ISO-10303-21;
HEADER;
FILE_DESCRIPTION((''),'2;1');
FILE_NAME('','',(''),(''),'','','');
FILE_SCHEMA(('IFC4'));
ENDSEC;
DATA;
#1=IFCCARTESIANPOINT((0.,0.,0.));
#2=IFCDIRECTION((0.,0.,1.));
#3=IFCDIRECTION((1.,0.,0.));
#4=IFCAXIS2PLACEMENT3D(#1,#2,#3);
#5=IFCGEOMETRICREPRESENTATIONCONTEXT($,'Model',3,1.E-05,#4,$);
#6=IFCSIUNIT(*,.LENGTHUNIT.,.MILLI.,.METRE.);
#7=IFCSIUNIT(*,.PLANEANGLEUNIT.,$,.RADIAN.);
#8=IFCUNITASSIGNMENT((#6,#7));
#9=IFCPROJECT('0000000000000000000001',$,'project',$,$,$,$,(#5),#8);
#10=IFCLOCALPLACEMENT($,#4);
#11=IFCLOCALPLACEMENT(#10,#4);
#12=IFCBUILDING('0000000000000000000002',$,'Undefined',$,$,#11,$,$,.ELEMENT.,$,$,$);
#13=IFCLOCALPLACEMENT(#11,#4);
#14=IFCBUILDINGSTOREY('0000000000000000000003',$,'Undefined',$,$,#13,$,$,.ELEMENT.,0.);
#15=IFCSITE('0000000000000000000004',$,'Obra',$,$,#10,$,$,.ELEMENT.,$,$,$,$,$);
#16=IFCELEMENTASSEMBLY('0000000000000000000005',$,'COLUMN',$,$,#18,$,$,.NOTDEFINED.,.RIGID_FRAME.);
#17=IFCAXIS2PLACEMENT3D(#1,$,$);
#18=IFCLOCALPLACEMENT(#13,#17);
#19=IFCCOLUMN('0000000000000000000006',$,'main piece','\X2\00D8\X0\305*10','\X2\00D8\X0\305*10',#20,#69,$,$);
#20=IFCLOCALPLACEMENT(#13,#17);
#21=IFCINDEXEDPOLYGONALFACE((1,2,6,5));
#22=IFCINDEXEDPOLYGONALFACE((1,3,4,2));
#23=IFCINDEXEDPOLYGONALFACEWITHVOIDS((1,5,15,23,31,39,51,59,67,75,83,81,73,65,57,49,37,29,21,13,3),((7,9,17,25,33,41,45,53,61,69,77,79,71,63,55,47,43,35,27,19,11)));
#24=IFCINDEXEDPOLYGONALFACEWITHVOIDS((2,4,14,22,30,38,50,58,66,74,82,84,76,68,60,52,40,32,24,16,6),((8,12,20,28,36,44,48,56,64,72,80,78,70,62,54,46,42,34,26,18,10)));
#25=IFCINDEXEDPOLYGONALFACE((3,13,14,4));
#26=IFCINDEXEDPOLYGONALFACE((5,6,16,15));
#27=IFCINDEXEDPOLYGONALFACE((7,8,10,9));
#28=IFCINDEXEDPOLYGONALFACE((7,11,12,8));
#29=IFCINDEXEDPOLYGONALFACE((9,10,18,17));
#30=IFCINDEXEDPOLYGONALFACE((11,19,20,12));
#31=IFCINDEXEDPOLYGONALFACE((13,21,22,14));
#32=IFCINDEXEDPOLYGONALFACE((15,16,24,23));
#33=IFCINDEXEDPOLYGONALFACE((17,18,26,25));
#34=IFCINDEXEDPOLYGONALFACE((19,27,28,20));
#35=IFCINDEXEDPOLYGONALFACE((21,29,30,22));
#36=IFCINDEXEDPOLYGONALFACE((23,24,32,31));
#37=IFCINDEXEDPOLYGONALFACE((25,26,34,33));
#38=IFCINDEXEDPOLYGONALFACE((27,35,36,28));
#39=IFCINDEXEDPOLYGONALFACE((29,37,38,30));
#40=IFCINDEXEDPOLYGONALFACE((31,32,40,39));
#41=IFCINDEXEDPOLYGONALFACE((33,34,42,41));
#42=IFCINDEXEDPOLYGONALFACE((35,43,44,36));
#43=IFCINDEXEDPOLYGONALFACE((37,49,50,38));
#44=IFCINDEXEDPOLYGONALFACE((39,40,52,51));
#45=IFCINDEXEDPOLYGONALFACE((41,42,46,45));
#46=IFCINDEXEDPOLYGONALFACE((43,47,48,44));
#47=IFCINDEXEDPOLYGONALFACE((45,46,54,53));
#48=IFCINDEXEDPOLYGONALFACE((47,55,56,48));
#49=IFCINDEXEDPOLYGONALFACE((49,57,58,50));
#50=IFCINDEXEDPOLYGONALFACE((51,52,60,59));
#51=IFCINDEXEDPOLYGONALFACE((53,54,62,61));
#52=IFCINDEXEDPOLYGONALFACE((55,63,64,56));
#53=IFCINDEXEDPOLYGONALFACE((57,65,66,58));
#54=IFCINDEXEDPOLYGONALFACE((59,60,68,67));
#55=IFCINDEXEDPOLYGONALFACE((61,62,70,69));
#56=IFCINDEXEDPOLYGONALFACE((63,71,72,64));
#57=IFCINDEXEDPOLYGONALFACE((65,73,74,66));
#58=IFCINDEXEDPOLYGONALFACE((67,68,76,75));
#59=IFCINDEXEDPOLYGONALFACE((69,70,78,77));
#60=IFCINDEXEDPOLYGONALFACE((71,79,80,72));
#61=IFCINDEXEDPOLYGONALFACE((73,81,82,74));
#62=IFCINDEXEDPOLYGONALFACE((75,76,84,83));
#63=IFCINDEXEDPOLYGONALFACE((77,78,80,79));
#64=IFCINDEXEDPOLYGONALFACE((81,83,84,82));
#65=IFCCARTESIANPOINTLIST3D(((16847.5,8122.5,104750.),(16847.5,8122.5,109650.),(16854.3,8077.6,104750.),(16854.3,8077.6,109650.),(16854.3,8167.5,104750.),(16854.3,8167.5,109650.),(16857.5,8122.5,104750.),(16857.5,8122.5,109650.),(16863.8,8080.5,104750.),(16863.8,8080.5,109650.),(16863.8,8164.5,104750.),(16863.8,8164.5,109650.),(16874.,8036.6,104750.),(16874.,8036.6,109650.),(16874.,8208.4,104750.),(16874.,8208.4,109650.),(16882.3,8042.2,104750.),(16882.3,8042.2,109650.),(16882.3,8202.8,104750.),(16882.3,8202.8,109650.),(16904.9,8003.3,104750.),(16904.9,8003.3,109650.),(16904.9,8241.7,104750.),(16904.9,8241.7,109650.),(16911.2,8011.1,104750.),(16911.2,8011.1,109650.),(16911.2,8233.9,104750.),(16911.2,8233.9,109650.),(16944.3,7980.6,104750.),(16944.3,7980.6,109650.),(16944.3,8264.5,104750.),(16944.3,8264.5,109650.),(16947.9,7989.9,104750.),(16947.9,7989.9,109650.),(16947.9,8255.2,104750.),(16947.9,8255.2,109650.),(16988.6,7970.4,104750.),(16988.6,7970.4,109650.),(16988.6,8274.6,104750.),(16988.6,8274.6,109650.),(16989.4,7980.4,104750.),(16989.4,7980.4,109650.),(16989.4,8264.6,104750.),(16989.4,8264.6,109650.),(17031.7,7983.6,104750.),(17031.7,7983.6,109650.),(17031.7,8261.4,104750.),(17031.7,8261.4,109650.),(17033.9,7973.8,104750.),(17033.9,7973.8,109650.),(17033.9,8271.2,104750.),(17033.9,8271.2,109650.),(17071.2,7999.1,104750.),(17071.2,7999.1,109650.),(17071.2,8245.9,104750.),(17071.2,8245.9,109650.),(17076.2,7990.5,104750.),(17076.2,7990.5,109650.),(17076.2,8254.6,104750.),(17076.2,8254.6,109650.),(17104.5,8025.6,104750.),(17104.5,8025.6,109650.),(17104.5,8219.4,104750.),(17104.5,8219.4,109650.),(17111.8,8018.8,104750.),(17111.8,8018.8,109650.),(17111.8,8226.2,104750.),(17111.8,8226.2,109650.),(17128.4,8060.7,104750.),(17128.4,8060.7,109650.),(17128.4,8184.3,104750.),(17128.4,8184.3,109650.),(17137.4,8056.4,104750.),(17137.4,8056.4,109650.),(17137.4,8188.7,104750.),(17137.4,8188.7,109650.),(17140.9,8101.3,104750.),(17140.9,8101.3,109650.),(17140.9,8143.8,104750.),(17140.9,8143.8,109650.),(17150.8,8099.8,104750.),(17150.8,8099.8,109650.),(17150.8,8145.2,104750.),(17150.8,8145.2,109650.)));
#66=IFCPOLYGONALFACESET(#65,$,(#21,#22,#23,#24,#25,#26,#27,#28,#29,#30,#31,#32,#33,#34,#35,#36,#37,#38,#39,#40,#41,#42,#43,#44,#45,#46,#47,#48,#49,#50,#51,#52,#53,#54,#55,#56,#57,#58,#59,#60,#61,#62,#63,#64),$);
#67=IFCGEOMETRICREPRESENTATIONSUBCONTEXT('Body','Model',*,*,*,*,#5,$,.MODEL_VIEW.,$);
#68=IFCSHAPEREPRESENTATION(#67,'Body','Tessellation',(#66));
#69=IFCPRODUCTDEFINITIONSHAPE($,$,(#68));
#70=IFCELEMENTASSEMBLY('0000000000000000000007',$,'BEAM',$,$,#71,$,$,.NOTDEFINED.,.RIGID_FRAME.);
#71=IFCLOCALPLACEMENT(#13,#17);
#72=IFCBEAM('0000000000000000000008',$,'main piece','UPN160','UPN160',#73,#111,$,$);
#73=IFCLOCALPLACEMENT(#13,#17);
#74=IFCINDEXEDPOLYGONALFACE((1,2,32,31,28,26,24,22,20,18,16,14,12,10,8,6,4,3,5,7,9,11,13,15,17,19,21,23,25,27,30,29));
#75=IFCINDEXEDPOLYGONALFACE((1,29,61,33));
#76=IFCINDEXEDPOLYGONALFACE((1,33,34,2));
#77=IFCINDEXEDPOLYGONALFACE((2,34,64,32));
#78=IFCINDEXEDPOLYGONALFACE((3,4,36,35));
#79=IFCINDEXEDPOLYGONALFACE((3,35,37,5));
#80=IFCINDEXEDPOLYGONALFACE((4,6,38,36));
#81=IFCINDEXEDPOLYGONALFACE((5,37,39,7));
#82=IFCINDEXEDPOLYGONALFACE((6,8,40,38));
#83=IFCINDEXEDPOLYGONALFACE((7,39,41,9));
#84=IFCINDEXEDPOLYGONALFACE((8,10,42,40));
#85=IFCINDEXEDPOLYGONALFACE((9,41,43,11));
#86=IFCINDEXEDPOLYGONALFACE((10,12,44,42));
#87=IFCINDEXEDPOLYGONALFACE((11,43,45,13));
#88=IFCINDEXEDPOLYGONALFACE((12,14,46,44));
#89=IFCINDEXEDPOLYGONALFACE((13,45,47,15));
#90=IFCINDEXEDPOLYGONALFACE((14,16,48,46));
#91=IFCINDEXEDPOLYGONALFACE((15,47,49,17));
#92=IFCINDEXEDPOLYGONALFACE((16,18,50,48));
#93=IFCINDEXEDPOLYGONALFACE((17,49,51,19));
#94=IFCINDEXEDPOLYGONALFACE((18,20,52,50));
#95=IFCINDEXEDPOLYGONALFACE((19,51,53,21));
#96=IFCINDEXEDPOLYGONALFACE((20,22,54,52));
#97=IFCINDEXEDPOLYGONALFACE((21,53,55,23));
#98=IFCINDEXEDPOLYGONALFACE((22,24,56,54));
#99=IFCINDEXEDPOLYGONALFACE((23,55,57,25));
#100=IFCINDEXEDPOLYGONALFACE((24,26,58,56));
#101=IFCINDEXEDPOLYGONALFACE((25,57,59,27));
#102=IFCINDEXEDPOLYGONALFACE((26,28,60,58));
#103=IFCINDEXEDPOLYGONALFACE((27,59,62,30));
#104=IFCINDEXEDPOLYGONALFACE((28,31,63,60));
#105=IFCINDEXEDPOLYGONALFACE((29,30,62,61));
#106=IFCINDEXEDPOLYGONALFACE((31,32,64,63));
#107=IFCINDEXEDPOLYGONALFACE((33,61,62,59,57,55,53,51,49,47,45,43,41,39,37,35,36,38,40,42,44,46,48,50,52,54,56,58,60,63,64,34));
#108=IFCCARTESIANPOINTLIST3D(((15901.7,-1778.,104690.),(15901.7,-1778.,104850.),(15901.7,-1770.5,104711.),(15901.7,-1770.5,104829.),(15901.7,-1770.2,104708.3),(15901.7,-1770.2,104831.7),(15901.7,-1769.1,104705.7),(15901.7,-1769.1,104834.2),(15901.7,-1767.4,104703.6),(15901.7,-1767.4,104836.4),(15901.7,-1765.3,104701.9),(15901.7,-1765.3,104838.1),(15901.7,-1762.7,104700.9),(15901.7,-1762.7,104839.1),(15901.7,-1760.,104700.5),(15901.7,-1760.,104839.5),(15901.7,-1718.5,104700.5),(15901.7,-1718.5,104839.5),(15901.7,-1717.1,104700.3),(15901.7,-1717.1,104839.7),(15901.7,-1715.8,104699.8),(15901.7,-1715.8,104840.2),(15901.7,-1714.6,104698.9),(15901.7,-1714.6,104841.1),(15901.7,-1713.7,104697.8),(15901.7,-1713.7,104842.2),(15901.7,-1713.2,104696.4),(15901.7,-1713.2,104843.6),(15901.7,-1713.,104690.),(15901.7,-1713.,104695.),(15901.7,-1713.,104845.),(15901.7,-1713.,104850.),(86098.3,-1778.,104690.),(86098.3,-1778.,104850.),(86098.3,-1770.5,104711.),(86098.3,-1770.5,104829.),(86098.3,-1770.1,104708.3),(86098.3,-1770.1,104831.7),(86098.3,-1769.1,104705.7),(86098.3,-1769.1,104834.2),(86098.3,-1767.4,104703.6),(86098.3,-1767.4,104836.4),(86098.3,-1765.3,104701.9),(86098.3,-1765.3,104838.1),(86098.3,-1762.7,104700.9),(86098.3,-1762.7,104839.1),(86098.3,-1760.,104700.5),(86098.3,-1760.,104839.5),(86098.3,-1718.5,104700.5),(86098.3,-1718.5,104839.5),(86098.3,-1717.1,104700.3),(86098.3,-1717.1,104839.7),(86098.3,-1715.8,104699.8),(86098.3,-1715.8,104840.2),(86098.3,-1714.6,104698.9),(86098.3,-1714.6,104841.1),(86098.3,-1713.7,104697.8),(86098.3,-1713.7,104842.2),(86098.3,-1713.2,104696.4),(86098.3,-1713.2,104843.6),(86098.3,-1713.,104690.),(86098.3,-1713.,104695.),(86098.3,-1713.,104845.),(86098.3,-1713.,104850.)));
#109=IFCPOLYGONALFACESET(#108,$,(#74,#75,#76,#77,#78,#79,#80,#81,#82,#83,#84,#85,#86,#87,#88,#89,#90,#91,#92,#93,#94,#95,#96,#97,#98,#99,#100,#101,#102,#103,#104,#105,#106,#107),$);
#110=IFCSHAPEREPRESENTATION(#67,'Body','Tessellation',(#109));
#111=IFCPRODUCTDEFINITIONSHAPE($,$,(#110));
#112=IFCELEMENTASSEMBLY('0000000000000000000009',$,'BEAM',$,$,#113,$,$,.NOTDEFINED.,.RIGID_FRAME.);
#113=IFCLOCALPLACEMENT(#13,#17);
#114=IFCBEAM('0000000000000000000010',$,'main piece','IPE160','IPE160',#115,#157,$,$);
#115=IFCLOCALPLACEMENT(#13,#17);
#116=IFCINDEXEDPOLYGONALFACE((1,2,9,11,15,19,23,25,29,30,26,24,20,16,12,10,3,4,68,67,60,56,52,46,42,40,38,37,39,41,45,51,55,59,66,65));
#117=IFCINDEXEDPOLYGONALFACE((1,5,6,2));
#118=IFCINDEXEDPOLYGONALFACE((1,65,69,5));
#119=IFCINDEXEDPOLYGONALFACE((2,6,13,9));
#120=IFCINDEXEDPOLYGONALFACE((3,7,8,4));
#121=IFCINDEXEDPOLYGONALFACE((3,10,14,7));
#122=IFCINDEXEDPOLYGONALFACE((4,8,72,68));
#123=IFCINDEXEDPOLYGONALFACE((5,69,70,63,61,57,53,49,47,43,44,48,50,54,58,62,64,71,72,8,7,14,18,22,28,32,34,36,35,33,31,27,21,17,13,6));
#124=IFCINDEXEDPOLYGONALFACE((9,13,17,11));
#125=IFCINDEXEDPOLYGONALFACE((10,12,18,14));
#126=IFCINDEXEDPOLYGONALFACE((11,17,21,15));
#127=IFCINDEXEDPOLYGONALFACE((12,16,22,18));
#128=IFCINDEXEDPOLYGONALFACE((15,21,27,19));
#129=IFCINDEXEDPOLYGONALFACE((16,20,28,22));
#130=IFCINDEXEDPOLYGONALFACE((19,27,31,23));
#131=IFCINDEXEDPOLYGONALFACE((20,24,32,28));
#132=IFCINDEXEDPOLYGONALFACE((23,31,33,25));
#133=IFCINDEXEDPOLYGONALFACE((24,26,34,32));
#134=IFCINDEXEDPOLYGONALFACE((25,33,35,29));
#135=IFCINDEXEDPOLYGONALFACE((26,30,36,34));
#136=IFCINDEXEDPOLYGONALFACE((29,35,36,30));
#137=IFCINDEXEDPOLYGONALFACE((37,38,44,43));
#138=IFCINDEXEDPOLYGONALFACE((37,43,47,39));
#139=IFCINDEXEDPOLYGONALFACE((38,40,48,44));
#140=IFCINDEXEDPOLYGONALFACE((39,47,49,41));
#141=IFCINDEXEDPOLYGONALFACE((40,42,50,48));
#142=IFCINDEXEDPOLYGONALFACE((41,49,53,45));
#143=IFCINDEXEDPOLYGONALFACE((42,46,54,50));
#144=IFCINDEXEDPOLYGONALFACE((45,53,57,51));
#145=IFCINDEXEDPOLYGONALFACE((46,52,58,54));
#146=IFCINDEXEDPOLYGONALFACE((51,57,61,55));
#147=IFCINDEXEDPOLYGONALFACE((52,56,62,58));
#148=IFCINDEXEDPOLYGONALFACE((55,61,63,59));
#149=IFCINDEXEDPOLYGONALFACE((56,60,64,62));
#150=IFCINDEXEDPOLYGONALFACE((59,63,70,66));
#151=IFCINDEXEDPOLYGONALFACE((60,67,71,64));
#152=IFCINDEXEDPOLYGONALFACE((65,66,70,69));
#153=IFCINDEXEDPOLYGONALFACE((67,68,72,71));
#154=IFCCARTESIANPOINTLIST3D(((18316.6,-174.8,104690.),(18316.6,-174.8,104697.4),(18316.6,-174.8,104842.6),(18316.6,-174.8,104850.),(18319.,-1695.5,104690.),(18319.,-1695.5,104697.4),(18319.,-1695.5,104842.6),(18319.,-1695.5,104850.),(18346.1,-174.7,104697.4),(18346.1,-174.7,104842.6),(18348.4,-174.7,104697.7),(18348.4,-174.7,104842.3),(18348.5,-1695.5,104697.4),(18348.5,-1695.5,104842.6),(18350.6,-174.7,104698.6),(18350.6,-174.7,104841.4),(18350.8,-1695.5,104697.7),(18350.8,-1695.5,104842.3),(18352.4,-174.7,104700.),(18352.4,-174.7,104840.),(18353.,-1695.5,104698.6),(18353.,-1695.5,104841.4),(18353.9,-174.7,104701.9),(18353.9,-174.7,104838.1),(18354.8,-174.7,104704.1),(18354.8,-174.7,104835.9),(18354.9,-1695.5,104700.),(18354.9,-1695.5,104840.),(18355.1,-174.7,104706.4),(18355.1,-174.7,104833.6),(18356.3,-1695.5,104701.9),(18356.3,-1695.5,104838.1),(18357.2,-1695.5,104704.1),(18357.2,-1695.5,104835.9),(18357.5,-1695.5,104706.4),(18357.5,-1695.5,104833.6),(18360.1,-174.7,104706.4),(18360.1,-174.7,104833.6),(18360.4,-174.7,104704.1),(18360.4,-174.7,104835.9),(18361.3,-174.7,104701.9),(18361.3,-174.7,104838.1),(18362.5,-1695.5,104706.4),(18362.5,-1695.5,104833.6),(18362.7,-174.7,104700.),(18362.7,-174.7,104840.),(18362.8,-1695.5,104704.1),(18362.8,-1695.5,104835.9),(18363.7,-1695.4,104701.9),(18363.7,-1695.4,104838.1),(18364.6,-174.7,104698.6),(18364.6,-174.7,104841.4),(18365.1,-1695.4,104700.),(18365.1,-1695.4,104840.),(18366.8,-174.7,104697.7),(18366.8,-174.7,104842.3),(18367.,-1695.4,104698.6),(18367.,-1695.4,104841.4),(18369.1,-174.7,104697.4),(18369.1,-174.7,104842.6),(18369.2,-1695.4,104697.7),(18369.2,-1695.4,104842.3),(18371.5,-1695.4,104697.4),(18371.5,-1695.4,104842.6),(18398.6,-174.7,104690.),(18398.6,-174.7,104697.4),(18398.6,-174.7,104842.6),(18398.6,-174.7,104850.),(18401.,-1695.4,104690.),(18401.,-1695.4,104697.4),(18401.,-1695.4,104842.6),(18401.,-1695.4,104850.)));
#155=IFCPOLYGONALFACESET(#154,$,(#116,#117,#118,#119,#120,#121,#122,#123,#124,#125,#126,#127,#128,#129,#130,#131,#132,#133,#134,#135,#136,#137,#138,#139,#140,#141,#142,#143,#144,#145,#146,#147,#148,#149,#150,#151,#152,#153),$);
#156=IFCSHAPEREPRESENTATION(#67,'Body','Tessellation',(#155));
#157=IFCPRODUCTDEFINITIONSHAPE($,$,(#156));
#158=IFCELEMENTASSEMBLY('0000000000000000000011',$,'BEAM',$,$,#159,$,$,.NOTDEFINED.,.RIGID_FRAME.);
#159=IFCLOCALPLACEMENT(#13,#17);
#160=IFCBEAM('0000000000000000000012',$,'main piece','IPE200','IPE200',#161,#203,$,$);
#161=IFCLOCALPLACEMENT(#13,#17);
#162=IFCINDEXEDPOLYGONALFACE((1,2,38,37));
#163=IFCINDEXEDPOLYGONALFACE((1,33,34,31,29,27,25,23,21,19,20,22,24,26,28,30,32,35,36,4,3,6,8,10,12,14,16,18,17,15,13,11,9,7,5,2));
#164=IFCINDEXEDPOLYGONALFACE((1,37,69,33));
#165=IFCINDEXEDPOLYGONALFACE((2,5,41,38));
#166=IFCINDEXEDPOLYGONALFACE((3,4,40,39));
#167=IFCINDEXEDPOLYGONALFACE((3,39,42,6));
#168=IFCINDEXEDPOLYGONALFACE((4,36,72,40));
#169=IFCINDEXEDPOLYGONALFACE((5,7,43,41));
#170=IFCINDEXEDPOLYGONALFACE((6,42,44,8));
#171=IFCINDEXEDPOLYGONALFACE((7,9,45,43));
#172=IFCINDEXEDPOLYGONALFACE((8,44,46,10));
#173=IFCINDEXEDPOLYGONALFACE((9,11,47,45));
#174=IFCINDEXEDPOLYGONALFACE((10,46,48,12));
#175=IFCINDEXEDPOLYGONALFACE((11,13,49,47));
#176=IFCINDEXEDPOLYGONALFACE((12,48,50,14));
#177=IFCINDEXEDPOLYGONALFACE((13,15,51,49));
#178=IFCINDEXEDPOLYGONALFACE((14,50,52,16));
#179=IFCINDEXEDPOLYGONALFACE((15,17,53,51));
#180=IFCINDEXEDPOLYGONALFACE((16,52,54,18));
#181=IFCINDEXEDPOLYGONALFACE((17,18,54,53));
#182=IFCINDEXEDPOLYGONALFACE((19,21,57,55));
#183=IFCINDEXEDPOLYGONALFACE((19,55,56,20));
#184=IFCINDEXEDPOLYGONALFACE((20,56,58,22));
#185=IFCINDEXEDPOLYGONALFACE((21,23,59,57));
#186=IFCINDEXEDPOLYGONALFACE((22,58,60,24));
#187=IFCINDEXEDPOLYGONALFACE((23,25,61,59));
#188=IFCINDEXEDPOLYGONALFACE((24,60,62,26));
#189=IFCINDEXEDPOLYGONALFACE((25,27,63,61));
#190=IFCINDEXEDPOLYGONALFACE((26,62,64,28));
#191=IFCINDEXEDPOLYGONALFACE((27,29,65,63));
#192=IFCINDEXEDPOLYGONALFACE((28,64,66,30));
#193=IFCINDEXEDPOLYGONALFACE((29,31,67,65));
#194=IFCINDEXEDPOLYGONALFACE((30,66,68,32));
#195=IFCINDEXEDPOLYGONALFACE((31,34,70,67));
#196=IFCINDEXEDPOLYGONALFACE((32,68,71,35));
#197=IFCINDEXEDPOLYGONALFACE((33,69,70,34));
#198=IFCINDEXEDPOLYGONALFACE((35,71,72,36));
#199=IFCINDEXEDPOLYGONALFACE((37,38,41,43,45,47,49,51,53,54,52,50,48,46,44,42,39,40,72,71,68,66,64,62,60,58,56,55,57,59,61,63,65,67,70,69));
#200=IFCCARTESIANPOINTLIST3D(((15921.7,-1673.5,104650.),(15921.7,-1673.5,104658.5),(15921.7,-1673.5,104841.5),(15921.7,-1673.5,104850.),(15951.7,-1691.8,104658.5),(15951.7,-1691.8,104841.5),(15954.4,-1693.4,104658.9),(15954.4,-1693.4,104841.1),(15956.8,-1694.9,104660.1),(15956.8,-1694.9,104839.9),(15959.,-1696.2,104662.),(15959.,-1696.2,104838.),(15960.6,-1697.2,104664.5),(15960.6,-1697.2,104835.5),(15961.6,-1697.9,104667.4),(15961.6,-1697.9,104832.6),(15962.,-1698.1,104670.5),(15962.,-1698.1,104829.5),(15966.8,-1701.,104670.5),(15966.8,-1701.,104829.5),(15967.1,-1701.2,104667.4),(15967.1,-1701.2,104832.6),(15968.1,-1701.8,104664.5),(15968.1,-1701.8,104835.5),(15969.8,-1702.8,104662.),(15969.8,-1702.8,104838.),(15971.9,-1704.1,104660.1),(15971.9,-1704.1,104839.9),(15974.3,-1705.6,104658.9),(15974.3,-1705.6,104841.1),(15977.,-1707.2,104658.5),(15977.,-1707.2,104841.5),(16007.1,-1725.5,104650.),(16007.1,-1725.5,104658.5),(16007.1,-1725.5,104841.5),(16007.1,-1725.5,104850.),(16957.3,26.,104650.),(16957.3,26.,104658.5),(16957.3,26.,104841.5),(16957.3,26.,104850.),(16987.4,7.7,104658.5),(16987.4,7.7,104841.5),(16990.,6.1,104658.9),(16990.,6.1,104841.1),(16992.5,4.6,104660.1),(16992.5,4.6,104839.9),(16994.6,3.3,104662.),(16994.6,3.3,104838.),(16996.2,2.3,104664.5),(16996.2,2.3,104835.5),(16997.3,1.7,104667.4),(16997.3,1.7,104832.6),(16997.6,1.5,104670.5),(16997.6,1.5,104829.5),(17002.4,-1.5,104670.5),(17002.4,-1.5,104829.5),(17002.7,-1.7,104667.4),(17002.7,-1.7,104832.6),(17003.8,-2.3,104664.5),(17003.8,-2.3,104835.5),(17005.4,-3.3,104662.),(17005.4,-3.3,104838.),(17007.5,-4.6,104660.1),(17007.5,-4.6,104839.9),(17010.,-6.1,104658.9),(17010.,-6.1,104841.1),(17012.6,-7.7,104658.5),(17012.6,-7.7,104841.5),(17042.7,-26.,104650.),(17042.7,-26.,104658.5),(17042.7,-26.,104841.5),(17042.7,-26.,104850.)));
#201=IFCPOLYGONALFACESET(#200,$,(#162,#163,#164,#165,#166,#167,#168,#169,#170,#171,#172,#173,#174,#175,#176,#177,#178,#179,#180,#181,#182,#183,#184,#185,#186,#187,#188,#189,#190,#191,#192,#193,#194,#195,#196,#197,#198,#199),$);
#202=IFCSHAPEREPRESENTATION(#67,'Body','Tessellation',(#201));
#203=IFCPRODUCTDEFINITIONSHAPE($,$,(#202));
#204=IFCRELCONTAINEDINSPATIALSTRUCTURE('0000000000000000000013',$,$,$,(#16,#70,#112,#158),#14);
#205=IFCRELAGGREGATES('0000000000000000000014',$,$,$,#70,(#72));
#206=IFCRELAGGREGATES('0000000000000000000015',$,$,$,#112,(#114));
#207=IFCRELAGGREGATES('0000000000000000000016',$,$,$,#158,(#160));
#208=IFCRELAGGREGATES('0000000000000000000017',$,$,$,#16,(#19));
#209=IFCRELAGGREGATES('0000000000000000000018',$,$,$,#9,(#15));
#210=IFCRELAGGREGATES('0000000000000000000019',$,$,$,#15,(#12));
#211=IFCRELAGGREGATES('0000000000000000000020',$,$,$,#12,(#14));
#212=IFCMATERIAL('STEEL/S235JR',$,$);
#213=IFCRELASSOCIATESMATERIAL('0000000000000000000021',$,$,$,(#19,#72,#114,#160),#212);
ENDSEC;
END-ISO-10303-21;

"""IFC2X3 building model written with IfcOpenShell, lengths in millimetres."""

from ifc_helpers import new_model, si_unit, frame, origin_with_axes, origin_2d_with_axis, place, context, subcontext, project, spatial, hollow_circle, i_section, u_section, extrude, material, element, aggregate, save


model = new_model("IFC2X3")

# Units and contexts
model_context = context("Model", 3, precision=1e-05, world=origin_with_axes())
body_context = subcontext(model_context, "Body", "Model", "MODEL_VIEW")
ifc_project = project(units=[si_unit("LENGTHUNIT", "METRE", prefix="MILLI"), si_unit("PLANEANGLEUNIT", "RADIAN")], contexts=[model_context])

# Site, building, storey
site_placement = place(None, origin_with_axes())
site = spatial("IfcSite", under=ifc_project, at=site_placement, Name="Obra", CompositionType="ELEMENT")
building_placement = place(site_placement, origin_with_axes())
building = spatial("IfcBuilding", under=site, at=building_placement, Name="Undefined", CompositionType="ELEMENT")
storey_placement = place(building_placement, origin_with_axes())
storey = spatial("IfcBuildingStorey", under=building, at=storey_placement, Name="Undefined", CompositionType="ELEMENT", Elevation=0.0)

# Element assembly, column
assembly_1_placement = place(storey_placement, origin_with_axes())
assembly_1 = element("IfcElementAssembly", 1, at=assembly_1_placement, inside=storey, Name="COLUMN", AssemblyPlace="NOTDEFINED", PredefinedType="RIGID_FRAME")
ifc_material_1 = material(Name="STEEL/S235JR")
column_placement = place(assembly_1_placement, frame((17000.0, 8122.5, 104750.0), z_axis=(0.0, 0.0, 1.0), x_axis=(0.0, 1.0, 0.0)))
column = element("IfcColumn", 2, at=column_placement, material=ifc_material_1, Name="main piece", Description="Ø305*10", ObjectType="Ø305*10", context=body_context, shape_type="SweptSolid", body=[
    extrude(hollow_circle(Radius=152.5, WallThickness=10.0, at=origin_2d_with_axis()), frame((0.0, 0.0, 4900.0), z_axis=(0.0, 0.0, -1.0), x_axis=(0.0, 1.0, 0.0)), (0.0, 0.0, 1.0), 4900.0),
])

# Element assemblies, beams
assembly_2_placement = place(storey_placement, origin_with_axes())
assembly_2 = element("IfcElementAssembly", 3, at=assembly_2_placement, inside=storey, Name="BEAM", AssemblyPlace="NOTDEFINED", PredefinedType="RIGID_FRAME")
beam_1_placement = place(assembly_2_placement, frame((15901.7, -1745.5, 104770.0), z_axis=(0.0, 0.0, -1.0), x_axis=(1.0, 0.0, 0.0)))
beam_1 = element("IfcBeam", 4, at=beam_1_placement, material=ifc_material_1, Name="main piece", Description="UPN160", ObjectType="UPN160", context=body_context, shape_type="SweptSolid", body=[
    extrude(u_section(Depth=160.0, FlangeWidth=65.0, WebThickness=7.5, FlangeThickness=10.5, FilletRadius=10.5, EdgeRadius=5.5, at=origin_2d_with_axis()), frame((70196.6, 0.0, 0.0), z_axis=(-1.0, 0.0, 0.0), x_axis=(0.0, -1.0, 0.0)), (0.0, 0.0, 1.0), 70196.6),
])
aggregate(assembly_2, [beam_1])
assembly_3_placement = place(storey_placement, origin_with_axes())
assembly_3 = element("IfcElementAssembly", 5, at=assembly_3_placement, inside=storey, Name="BEAM", AssemblyPlace="NOTDEFINED", PredefinedType="RIGID_FRAME")
beam_2_placement = place(assembly_3_placement, frame((18360.0, -1695.5, 104770.0), z_axis=(0.0, 0.0, 1.0), x_axis=(-0.001588, 0.999999, 0.0)))
beam_2 = element("IfcBeam", 6, at=beam_2_placement, material=ifc_material_1, Name="main piece", Description="IPE160", ObjectType="IPE160", context=body_context, shape_type="SweptSolid", body=[
    extrude(i_section(OverallWidth=82.0, OverallDepth=160.0, WebThickness=5.0, FlangeThickness=7.4, FilletRadius=9.0, at=origin_2d_with_axis()), frame((1520.7, 0.0, 0.0), z_axis=(-1.0, 0.0, 0.0), x_axis=(0.0, -1.0, 0.0)), (0.0, 0.0, 1.0), 1520.7),
])
aggregate(assembly_3, [beam_2])
assembly_4_placement = place(storey_placement, origin_with_axes())
assembly_4 = element("IfcElementAssembly", 7, at=assembly_4_placement, inside=storey, Name="BEAM", AssemblyPlace="NOTDEFINED", PredefinedType="RIGID_FRAME")
beam_3_placement = place(assembly_4_placement, frame((17000.0, 0.0, 104750.0), z_axis=(0.0, 0.0, 1.0), x_axis=(-0.520368, -0.853942, 0.0)))
beam_3 = element("IfcBeam", 8, at=beam_3_placement, material=ifc_material_1, Name="main piece", Description="IPE200", ObjectType="IPE200", context=body_context, shape_type="SweptSolid", body=[
    extrude(i_section(OverallWidth=100.0, OverallDepth=200.0, WebThickness=5.6, FlangeThickness=8.5, FilletRadius=12.0, at=origin_2d_with_axis()), frame((1990.2, 0.0, 0.0), z_axis=(-1.0, 0.0, 0.0), x_axis=(0.0, -1.0, 0.0)), (0.0, 0.0, 1.0), 1990.2),
])
aggregate(assembly_4, [beam_3])

aggregate(assembly_1, [column])

save(model, "model.ifc")
